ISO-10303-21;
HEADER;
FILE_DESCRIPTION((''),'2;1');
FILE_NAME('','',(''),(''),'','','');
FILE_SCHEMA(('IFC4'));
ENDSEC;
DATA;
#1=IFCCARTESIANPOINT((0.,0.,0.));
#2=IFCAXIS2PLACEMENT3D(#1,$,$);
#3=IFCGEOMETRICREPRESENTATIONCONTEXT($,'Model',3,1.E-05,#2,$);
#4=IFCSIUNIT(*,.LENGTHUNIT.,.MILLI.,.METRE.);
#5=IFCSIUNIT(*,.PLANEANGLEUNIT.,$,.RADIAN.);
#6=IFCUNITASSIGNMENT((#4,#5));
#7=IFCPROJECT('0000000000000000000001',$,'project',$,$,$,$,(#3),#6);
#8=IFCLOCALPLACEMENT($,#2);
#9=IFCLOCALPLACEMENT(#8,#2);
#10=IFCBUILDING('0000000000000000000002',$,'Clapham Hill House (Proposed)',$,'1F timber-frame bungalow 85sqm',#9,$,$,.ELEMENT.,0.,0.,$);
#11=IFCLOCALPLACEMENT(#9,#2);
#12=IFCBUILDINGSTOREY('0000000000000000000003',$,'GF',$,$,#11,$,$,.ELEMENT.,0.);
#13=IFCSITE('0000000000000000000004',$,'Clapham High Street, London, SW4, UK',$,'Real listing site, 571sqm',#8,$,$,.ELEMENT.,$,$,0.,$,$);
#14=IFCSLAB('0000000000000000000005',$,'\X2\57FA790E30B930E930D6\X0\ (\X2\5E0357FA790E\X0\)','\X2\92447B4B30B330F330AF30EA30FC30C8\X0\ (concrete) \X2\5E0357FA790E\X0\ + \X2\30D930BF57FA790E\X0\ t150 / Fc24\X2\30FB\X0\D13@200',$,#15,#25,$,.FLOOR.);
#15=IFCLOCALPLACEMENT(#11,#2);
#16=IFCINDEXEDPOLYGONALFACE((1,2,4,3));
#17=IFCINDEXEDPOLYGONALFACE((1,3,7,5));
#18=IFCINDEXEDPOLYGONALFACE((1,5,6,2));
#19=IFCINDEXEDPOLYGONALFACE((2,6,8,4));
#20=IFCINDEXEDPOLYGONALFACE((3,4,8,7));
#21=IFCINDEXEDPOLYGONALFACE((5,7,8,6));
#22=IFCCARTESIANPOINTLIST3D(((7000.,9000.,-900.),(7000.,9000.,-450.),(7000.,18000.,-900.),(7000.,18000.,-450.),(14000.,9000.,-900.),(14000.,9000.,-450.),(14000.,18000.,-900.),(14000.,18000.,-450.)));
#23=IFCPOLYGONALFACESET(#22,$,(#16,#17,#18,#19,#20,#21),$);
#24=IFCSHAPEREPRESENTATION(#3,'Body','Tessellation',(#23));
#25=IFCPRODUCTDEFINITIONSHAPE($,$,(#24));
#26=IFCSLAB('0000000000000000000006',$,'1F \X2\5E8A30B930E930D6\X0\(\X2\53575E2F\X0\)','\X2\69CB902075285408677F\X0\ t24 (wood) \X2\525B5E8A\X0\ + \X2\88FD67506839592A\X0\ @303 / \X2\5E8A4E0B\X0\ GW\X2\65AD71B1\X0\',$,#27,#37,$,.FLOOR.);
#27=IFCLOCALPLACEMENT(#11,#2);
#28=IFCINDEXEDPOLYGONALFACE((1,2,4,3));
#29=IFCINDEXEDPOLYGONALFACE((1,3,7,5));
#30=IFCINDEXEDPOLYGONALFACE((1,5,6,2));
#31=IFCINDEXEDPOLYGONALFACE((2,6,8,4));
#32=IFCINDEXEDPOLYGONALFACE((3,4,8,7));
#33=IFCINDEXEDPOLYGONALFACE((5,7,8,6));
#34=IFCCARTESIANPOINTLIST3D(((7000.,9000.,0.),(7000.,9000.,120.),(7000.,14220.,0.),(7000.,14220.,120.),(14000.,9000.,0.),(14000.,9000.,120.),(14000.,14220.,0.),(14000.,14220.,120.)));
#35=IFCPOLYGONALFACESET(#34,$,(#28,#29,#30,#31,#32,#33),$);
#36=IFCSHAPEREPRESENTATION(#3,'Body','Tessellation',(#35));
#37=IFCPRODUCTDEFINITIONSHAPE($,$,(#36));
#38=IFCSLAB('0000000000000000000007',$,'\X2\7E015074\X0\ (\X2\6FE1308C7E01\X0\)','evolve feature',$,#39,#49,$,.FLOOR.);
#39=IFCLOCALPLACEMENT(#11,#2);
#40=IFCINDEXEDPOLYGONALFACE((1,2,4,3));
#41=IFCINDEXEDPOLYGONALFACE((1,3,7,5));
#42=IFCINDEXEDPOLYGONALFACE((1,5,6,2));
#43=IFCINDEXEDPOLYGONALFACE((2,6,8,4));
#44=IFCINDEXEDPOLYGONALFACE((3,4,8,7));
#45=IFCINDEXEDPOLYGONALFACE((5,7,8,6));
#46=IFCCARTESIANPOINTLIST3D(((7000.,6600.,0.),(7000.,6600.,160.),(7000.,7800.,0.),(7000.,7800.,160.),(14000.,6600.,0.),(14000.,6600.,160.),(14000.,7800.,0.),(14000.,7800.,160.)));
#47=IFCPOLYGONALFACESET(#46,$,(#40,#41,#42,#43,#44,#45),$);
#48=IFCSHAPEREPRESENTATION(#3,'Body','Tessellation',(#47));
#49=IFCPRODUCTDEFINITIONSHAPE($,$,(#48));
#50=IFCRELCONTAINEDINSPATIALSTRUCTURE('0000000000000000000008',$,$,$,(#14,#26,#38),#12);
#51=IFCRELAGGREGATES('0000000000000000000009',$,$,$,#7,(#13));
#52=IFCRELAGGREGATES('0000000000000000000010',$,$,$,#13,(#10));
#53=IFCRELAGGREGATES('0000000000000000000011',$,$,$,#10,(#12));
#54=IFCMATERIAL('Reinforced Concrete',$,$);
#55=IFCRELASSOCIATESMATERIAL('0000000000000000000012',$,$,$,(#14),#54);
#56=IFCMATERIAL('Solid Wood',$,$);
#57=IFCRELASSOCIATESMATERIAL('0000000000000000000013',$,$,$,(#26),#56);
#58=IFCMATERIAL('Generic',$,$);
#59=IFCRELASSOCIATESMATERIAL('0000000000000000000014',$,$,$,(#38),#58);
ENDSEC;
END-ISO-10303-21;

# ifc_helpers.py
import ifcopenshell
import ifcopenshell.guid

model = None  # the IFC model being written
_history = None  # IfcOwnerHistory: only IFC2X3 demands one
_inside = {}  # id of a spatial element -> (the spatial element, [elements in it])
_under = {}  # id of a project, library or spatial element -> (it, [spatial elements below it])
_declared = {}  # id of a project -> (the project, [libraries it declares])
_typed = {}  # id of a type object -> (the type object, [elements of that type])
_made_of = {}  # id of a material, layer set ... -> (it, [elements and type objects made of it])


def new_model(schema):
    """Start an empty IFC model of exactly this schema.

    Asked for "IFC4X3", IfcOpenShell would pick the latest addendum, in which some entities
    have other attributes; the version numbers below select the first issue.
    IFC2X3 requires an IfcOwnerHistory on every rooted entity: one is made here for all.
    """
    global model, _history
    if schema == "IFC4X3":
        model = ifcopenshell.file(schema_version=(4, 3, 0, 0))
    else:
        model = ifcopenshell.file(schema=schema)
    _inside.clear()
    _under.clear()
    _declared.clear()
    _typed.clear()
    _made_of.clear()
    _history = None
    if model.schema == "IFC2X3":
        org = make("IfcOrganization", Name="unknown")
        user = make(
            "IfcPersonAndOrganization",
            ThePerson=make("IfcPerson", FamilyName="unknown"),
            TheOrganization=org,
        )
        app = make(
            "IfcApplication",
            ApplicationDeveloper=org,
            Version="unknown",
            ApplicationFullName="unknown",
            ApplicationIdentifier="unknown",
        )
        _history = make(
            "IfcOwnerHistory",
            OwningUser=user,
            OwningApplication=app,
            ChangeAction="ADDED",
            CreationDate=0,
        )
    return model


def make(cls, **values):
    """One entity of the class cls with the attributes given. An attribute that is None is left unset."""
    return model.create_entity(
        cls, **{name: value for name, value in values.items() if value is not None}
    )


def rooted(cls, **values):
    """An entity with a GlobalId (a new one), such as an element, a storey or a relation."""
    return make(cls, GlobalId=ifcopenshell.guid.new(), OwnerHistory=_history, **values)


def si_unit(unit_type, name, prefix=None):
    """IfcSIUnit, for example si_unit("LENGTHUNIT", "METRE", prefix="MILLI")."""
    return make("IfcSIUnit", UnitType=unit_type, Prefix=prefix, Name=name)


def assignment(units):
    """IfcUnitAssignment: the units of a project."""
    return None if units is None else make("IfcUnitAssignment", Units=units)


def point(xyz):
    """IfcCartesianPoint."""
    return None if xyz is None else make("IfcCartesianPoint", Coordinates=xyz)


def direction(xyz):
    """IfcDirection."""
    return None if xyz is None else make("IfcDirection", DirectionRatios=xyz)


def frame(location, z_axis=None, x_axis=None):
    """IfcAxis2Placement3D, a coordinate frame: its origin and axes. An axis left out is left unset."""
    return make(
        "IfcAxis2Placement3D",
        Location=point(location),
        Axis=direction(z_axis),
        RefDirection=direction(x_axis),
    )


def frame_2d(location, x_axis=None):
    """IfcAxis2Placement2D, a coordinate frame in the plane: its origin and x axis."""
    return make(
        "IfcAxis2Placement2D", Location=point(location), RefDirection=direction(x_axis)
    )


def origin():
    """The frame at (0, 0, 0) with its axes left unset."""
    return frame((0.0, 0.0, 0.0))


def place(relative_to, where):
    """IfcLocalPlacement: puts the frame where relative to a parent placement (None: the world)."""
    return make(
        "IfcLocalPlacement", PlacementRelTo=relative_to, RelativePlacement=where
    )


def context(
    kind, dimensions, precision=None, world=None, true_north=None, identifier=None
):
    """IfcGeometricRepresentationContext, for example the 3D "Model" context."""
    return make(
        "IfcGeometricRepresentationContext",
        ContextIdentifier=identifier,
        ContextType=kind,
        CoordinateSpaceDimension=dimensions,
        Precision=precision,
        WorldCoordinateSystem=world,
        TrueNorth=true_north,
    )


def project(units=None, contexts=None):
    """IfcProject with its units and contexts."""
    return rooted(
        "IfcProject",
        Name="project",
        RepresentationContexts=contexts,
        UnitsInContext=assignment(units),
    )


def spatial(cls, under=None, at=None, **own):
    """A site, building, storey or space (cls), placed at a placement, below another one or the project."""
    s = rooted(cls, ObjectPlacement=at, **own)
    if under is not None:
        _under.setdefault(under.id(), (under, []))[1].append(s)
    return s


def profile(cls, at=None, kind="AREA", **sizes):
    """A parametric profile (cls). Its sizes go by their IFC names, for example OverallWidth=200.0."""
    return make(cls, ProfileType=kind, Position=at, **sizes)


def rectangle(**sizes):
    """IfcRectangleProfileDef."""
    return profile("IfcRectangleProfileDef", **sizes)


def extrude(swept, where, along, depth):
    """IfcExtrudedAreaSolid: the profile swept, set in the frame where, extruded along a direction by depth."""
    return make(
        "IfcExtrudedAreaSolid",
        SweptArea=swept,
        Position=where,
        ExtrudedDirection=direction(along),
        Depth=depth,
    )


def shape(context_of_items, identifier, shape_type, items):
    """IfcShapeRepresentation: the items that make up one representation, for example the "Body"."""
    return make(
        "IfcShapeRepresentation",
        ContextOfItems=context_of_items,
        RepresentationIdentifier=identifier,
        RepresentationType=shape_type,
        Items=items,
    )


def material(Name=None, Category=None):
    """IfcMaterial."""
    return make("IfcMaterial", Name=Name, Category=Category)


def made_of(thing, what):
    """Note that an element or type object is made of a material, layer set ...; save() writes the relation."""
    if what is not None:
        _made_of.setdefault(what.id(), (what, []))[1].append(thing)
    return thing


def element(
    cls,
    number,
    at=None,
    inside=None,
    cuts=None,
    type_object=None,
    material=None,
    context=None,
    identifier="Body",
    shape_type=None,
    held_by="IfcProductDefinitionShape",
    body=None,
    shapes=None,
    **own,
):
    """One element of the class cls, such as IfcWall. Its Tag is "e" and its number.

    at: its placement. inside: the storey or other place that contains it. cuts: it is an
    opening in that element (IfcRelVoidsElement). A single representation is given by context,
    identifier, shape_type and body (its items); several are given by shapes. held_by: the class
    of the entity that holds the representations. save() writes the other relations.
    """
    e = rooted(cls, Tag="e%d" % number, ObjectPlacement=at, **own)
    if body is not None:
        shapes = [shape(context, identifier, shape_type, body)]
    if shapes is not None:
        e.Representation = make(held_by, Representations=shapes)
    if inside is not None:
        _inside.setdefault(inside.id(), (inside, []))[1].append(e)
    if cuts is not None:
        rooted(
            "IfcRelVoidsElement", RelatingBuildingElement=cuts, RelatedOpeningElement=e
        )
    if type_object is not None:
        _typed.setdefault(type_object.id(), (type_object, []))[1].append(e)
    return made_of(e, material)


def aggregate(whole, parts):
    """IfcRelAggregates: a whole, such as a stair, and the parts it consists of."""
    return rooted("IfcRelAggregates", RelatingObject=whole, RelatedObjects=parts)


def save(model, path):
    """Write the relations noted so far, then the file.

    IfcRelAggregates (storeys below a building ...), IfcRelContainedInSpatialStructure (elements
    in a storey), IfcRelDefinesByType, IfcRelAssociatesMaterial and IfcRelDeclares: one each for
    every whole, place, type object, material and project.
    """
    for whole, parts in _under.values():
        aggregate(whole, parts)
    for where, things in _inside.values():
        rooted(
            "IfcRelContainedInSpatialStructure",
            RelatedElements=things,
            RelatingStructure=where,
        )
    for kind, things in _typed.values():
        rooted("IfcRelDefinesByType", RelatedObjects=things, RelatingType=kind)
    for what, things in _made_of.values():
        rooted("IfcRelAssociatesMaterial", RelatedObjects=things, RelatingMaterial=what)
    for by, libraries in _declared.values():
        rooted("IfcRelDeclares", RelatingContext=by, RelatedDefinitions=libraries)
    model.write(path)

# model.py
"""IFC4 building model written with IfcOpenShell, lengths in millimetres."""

from ifc_helpers import new_model, si_unit, frame, frame_2d, origin, place, context, project, spatial, rectangle, extrude, material, element, save


model = new_model("IFC4")

# Units and contexts
model_context = context("Model", 3, precision=1e-05, world=origin())
ifc_project = project(units=[si_unit("LENGTHUNIT", "METRE", prefix="MILLI"), si_unit("PLANEANGLEUNIT", "RADIAN")], contexts=[model_context])

# Site, building, storey
site_placement = place(None, origin())
site = spatial("IfcSite", under=ifc_project, at=site_placement, Name="Clapham High Street, London, SW4, UK", ObjectType="Real listing site, 571sqm", CompositionType="ELEMENT", RefElevation=0.0)
building_placement = place(site_placement, origin())
building = spatial("IfcBuilding", under=site, at=building_placement, Name="Clapham Hill House (Proposed)", ObjectType="1F timber-frame bungalow 85sqm", CompositionType="ELEMENT", ElevationOfRefHeight=0.0, ElevationOfTerrain=0.0)
storey_placement = place(building_placement, origin())
storey = spatial("IfcBuildingStorey", under=building, at=storey_placement, Name="GF", CompositionType="ELEMENT", Elevation=0.0)

# Slabs
ifc_material_1 = material(Name="Reinforced Concrete")
slab_1_placement = place(storey_placement, frame((3500.0, 4500.0, -450.0)))
element("IfcSlab", 1, at=slab_1_placement, inside=storey, material=ifc_material_1, Name="基礎スラブ (布基礎)", Description="鉄筋コンクリート (concrete) 布基礎 + ベタ基礎 t150 / Fc24・D13@200", PredefinedType="FLOOR", context=model_context, shape_type="SweptSolid", body=[
    extrude(rectangle(XDim=7000.0, YDim=9000.0, at=frame_2d((3500.0, 4500.0))), frame((3500.0, 4500.0, -450.0)), (0.0, 0.0, 1.0), 450.0),
])
ifc_material_2 = material(Name="Solid Wood")
slab_2_placement = place(storey_placement, frame((3500.0, 4500.0, 0.0)))
element("IfcSlab", 2, at=slab_2_placement, inside=storey, material=ifc_material_2, Name="1F 床スラブ(南帯)", Description="構造用合板 t24 (wood) 剛床 + 製材根太 @303 / 床下 GW断熱", PredefinedType="FLOOR", context=model_context, shape_type="SweptSolid", body=[
    extrude(rectangle(XDim=7000.0, YDim=5220.0, at=frame_2d((3500.0, 2610.0))), frame((3500.0, 4500.0, 0.0)), (0.0, 0.0, 1.0), 120.0),
])
ifc_material_3 = material(Name="Generic")
slab_3_placement = place(storey_placement, frame((3500.0, 3300.0, 0.0)))
element("IfcSlab", 3, at=slab_3_placement, inside=storey, material=ifc_material_3, Name="縁側 (濡れ縁)", Description="evolve feature", PredefinedType="FLOOR", context=model_context, shape_type="SweptSolid", body=[
    extrude(rectangle(XDim=7000.0, YDim=1200.0, at=frame_2d((3500.0, 600.0))), frame((3500.0, 3300.0, 0.0)), (0.0, 0.0, 1.0), 160.0),
])

save(model, "model.ifc")
